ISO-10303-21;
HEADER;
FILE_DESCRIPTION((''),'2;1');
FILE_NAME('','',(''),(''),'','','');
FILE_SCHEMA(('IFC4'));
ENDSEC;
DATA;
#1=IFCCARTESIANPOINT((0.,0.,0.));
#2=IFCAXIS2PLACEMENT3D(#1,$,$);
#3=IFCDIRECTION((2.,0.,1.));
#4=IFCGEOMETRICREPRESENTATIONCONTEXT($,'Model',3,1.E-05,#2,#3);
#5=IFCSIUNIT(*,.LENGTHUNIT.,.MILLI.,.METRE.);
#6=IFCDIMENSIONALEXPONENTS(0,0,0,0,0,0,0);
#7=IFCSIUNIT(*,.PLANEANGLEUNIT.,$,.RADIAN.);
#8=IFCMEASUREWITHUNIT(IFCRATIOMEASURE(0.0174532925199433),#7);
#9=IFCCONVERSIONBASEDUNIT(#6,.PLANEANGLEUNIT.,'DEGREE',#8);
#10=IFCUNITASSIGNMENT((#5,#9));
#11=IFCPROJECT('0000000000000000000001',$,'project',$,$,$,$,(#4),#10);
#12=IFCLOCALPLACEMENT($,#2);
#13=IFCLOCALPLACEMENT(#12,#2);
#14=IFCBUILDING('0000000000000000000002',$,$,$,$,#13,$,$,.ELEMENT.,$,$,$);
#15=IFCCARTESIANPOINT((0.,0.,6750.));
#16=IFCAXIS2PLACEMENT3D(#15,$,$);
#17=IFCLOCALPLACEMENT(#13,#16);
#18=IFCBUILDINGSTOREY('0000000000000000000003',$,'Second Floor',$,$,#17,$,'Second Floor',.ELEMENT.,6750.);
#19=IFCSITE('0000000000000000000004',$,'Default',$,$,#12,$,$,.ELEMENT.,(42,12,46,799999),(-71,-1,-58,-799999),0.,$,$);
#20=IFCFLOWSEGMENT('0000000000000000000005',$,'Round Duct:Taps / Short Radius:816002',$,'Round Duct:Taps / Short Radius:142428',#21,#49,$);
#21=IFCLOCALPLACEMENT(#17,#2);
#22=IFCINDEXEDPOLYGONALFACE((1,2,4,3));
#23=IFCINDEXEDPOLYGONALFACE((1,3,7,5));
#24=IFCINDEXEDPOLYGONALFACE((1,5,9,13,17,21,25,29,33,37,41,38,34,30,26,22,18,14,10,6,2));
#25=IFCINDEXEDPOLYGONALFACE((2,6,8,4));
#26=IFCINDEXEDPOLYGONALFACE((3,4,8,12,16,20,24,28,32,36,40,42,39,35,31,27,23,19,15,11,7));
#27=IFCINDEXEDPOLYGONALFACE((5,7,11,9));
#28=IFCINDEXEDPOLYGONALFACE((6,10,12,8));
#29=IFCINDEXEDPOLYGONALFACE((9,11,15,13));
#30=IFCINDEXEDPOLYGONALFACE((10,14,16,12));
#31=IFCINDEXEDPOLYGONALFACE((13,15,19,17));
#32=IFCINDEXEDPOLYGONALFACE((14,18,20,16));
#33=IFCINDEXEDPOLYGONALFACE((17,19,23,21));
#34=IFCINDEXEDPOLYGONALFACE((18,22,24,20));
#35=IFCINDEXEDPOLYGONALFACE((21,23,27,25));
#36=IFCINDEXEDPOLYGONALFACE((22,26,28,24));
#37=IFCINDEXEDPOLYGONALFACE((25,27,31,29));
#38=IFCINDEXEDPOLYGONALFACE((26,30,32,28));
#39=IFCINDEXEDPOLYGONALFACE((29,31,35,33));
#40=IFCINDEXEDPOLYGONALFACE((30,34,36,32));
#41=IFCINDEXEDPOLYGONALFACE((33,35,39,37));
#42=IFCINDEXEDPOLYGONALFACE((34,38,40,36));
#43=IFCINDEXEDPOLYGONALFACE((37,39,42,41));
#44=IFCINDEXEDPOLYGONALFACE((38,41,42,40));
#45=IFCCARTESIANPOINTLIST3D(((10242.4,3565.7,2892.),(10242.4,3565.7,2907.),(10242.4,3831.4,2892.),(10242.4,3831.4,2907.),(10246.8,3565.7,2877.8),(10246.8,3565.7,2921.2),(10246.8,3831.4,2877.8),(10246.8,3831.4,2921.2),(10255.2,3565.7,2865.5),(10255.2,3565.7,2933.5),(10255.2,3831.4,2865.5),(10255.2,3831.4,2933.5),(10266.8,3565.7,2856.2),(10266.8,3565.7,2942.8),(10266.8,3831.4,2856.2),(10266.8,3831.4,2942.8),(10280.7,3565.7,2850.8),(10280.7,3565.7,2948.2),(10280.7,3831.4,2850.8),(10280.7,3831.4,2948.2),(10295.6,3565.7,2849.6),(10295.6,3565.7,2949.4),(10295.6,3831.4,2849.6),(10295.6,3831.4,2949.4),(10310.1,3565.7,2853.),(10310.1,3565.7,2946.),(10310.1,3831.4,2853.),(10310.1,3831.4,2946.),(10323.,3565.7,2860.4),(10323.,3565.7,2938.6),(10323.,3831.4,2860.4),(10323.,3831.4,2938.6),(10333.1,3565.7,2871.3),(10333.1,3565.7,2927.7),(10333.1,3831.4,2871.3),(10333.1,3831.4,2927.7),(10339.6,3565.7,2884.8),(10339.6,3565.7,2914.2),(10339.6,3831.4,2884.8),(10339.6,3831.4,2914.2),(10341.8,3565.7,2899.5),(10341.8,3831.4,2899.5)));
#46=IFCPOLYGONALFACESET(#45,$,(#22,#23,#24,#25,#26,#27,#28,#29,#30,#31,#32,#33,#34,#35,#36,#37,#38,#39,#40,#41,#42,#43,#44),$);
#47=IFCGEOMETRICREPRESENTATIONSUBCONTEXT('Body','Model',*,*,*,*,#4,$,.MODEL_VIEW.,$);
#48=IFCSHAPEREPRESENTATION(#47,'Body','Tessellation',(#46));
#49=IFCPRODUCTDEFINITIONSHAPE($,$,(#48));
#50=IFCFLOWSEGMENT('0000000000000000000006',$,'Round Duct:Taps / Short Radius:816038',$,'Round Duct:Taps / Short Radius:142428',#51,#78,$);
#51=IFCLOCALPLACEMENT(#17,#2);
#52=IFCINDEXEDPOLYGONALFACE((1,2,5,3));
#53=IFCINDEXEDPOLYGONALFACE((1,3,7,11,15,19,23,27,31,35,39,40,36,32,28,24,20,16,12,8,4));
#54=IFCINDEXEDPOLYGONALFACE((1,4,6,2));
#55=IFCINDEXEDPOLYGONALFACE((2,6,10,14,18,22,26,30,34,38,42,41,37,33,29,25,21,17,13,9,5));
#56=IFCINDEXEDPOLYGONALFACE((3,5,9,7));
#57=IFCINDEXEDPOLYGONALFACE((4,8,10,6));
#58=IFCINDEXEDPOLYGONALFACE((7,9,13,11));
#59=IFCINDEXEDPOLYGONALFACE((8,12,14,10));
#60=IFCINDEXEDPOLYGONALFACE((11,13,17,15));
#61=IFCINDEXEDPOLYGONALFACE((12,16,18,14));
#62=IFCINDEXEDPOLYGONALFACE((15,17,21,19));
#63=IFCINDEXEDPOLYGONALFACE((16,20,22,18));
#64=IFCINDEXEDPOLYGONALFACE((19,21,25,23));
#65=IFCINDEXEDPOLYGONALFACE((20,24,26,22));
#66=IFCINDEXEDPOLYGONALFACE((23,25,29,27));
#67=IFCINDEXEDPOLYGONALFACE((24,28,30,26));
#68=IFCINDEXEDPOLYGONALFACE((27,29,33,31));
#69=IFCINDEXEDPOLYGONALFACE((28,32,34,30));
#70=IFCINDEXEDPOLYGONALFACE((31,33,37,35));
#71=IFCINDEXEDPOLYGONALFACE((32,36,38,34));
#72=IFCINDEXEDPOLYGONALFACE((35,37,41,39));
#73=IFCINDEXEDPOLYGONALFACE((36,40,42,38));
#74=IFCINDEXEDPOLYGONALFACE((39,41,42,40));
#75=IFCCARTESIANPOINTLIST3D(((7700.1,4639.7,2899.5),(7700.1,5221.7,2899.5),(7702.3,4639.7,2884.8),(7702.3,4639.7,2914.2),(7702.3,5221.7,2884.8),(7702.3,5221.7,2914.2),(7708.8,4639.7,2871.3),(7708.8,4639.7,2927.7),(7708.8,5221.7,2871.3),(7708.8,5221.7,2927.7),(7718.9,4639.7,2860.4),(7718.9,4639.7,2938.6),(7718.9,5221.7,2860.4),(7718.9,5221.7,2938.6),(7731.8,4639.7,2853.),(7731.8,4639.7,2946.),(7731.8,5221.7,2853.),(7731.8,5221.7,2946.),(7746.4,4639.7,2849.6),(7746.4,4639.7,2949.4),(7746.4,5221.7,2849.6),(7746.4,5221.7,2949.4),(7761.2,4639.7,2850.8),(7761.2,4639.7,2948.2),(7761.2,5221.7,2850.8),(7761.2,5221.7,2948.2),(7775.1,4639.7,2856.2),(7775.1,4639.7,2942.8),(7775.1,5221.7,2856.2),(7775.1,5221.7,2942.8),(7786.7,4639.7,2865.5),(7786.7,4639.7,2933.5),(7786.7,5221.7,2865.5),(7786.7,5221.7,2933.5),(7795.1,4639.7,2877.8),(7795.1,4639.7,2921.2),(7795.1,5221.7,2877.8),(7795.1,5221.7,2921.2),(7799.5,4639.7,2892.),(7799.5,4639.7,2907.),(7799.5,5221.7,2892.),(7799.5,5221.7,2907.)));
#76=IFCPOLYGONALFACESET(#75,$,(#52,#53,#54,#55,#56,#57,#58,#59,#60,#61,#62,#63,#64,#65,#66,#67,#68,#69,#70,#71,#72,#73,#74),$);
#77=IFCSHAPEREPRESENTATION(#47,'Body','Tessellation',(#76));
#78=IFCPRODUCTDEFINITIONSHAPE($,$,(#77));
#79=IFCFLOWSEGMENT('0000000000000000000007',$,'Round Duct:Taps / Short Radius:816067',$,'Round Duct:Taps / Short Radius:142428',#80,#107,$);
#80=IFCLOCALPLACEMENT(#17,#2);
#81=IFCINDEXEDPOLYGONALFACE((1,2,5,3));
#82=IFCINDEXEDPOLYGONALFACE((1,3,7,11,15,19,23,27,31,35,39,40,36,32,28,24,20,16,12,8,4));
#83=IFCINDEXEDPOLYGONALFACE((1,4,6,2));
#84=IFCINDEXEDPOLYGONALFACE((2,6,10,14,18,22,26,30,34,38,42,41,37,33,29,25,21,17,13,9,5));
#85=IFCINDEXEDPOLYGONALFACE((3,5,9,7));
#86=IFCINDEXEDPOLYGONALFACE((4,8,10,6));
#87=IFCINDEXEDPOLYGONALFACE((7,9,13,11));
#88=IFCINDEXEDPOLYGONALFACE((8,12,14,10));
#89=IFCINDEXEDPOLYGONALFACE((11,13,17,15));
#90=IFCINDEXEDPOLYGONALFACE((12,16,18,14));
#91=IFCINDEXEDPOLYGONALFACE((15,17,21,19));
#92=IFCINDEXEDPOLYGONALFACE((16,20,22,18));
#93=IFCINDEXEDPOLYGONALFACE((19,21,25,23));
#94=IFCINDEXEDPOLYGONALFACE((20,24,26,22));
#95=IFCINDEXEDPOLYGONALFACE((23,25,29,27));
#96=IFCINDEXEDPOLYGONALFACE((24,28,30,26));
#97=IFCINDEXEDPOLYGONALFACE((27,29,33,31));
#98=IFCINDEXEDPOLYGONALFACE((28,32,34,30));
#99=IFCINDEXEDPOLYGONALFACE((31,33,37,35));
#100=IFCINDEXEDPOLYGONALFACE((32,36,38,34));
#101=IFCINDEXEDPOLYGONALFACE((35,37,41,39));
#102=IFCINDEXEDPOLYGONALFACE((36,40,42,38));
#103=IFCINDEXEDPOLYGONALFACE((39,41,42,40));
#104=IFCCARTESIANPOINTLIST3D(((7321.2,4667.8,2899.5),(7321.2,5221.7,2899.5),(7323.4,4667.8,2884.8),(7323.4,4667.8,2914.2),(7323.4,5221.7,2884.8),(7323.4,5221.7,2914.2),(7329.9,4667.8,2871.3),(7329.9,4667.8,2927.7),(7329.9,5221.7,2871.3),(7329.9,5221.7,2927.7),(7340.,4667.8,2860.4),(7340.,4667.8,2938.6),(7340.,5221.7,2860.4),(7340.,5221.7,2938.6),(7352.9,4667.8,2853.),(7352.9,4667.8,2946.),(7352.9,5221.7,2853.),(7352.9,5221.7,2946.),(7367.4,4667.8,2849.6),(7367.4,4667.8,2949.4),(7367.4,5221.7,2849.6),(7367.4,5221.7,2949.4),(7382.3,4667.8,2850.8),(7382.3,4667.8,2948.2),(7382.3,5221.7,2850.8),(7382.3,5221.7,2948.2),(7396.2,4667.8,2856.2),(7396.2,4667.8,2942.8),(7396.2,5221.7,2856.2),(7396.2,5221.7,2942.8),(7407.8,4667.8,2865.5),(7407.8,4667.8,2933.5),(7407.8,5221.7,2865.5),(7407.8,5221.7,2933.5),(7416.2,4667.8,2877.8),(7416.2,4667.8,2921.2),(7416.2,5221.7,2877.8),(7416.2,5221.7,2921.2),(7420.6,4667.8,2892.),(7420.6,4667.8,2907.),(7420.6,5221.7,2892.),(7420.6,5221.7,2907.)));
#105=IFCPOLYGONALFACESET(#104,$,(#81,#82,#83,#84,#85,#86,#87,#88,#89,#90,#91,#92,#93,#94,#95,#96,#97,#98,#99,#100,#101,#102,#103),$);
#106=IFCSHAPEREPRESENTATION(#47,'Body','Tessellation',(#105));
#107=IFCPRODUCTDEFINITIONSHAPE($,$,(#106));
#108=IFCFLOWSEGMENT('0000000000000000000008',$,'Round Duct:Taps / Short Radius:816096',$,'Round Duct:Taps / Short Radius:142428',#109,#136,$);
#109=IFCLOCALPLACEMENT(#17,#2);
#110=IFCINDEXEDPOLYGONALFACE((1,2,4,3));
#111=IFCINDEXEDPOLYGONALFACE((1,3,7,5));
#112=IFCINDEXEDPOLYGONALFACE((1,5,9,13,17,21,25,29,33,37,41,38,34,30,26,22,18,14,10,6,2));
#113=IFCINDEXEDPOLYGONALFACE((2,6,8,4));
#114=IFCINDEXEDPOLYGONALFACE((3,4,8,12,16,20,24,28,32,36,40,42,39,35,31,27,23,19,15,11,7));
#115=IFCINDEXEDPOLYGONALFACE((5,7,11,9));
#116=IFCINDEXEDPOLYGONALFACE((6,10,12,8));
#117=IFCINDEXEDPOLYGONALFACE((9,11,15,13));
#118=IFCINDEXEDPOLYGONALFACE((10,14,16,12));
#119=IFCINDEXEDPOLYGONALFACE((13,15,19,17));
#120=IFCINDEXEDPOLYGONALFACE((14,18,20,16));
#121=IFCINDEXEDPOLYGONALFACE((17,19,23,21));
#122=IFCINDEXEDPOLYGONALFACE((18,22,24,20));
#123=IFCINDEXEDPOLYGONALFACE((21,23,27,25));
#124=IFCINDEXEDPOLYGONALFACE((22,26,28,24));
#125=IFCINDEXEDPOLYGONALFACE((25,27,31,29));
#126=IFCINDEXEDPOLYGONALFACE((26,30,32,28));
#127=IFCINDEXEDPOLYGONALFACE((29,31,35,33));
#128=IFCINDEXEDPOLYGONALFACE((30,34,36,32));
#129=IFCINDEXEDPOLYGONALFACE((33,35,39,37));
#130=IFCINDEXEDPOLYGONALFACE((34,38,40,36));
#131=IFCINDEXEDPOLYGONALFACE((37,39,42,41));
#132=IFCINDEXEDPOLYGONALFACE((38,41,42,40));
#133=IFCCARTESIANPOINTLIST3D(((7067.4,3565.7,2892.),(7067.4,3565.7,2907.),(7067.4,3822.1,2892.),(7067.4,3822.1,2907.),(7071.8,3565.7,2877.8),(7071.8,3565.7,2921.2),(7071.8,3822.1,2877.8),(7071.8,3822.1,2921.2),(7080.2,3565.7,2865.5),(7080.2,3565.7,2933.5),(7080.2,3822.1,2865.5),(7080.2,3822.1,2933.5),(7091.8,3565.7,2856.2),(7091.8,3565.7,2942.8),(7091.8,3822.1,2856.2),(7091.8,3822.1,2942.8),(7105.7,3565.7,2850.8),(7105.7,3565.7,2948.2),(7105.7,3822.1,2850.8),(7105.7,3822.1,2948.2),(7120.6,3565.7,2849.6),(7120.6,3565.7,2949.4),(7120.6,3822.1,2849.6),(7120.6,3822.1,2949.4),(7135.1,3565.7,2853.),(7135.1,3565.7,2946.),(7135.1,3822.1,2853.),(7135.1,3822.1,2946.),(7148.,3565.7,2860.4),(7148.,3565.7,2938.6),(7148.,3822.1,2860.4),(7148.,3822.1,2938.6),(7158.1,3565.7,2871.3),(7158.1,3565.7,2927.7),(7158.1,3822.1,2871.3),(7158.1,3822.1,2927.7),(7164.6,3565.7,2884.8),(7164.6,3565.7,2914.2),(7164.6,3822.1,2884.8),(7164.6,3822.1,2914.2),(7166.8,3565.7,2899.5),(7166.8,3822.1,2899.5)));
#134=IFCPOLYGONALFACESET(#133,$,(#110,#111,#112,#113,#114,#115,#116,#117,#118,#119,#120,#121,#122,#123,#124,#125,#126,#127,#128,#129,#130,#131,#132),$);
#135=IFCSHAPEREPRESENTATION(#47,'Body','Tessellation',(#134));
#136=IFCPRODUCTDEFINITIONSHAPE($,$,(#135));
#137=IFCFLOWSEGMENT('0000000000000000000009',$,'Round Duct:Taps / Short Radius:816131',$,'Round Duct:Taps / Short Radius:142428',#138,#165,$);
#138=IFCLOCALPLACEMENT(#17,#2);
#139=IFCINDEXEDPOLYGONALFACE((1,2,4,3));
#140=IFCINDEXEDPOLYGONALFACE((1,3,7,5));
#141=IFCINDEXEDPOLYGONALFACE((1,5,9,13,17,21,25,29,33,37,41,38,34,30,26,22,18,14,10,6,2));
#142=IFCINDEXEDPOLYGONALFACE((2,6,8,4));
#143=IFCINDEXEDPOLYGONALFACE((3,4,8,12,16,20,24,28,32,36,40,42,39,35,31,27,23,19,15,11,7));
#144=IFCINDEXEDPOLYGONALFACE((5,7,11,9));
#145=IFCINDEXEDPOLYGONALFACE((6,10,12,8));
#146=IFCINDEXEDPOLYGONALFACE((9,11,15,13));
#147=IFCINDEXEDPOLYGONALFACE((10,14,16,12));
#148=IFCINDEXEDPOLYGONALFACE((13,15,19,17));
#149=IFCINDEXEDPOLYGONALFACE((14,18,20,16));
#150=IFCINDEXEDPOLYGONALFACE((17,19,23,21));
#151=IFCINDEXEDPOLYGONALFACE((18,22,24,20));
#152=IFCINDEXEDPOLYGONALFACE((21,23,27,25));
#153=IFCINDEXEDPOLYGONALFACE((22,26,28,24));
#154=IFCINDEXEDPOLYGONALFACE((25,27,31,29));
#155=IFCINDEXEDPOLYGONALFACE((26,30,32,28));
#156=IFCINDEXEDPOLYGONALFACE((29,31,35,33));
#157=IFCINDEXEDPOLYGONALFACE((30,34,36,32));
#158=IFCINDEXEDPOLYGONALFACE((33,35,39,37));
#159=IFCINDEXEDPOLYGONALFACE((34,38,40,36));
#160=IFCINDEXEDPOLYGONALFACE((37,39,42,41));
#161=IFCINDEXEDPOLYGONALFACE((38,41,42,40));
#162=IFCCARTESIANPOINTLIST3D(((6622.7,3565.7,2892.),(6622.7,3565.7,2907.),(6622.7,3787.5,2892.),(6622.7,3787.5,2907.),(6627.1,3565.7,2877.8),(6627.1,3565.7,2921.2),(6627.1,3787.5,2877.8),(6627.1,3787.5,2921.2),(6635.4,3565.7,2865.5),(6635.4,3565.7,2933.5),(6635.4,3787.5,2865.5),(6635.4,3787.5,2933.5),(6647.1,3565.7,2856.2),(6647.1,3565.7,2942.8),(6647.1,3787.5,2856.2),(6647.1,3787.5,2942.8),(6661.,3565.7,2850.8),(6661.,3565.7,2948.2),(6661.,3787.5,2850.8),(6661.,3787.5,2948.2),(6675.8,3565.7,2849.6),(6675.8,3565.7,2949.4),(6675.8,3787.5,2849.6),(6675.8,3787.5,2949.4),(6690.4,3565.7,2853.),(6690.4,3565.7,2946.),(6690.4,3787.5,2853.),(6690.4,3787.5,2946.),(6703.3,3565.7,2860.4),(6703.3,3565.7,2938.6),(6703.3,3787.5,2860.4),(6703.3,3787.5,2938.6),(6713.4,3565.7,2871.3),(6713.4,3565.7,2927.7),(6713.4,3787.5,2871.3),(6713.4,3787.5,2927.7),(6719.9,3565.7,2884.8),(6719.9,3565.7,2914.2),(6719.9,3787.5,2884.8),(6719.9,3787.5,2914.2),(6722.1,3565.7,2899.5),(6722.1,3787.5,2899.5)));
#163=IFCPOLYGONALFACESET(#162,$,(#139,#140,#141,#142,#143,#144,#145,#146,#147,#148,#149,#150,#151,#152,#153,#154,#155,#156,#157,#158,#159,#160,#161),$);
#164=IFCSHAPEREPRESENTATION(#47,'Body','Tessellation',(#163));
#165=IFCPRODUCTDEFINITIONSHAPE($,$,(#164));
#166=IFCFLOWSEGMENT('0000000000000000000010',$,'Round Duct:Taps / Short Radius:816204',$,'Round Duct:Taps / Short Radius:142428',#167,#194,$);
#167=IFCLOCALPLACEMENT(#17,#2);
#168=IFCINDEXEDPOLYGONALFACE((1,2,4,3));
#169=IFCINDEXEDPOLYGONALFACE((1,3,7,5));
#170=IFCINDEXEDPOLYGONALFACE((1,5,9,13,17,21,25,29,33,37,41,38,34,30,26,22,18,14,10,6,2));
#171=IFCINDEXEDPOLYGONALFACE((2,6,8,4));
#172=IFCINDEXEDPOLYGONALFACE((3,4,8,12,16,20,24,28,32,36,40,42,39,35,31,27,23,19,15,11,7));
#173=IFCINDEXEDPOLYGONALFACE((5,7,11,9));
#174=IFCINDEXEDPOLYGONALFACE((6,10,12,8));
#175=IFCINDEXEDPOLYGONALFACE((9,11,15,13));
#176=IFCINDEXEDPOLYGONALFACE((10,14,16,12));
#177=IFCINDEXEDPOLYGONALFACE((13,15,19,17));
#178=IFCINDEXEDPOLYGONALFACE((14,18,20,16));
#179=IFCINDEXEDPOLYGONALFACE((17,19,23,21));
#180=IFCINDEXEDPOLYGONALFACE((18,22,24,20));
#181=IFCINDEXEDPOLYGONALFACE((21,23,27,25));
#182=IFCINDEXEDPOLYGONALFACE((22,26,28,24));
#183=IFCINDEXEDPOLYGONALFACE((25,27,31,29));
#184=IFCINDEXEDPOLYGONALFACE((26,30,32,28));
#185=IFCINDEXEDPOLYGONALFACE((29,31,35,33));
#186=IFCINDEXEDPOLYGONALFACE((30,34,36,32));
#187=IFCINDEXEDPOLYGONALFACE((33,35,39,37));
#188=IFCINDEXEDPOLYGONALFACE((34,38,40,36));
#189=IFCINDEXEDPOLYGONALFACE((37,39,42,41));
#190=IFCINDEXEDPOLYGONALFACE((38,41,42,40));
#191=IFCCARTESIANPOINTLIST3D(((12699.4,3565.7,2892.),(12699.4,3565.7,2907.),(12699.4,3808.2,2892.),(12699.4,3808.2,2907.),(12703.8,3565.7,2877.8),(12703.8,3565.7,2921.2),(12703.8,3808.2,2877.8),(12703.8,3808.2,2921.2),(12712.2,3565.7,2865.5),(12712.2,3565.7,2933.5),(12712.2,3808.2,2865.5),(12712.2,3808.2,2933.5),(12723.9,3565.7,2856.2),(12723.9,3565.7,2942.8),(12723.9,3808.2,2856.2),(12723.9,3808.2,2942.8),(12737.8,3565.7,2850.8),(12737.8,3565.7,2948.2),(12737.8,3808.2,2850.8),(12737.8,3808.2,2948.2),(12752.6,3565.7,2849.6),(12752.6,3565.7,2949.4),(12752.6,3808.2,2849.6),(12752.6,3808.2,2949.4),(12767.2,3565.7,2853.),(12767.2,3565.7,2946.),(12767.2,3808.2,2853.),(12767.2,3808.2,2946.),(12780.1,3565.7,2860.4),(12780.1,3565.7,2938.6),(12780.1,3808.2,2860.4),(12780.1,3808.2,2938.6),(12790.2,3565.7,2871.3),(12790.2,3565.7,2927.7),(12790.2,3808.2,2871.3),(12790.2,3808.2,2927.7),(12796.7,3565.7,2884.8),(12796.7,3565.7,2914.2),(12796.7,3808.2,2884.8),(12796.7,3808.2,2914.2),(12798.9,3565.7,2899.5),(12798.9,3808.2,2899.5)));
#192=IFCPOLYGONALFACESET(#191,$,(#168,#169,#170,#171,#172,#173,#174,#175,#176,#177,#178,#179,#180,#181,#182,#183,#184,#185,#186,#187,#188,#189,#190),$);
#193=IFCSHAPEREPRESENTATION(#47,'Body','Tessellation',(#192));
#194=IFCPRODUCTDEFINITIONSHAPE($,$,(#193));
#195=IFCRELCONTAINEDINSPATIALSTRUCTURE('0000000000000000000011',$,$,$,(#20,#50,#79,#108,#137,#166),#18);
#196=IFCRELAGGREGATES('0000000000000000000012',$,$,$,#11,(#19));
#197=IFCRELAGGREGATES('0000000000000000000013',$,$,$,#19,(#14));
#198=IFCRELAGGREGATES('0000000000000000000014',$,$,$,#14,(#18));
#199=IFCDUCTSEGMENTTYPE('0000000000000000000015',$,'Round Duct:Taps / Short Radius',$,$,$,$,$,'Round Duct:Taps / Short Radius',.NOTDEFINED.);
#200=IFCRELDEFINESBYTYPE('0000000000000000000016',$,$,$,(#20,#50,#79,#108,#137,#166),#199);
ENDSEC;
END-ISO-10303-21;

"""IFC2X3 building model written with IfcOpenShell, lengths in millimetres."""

from ifc_helpers import new_model, entity, si_unit, converted_unit, direction, frame, frame_2d, origin, origin_2d_with_axis, place, context, subcontext, project, spatial, circle, extrude, type_object, element, save


model = new_model("IFC2X3")

# Units and contexts
model_context = context("Model", 3, precision=1e-05, world=origin(), true_north=direction((2.0, 0.0, 1.0)))
body_context = subcontext(model_context, "Body", "Model", "MODEL_VIEW")
ifc_project = project(units=[si_unit("LENGTHUNIT", "METRE", prefix="MILLI"), converted_unit("PLANEANGLEUNIT", "DEGREE", entity("IfcRatioMeasure", 0.0174532925199433), si_unit("PLANEANGLEUNIT", "RADIAN"), dimensions=[0, 0, 0, 0, 0, 0, 0])], contexts=[model_context])

# Site, building, storey
site_placement = place(None, origin())
site = spatial("IfcSite", under=ifc_project, at=site_placement, Name="Default", CompositionType="ELEMENT", RefLatitude=(42, 12, 46, 799999), RefLongitude=(-71, -1, -58, -799999), RefElevation=0.0)
building_placement = place(site_placement, origin())
building = spatial("IfcBuilding", under=site, at=building_placement, CompositionType="ELEMENT")
storey_placement = place(building_placement, frame((0.0, 0.0, 6750.0)))
storey = spatial("IfcBuildingStorey", under=building, at=storey_placement, Name="Second Floor", LongName="Second Floor", CompositionType="ELEMENT", Elevation=6750.0)

# Flow segments
duct_segment_type = type_object("IfcDuctSegmentType", Name="Round Duct:Taps / Short Radius", ElementType="Round Duct:Taps / Short Radius", PredefinedType="NOTDEFINED")
flow_segment_1_placement = place(storey_placement, origin())
element("IfcFlowSegment", 1, at=flow_segment_1_placement, inside=storey, type_object=duct_segment_type, Name="Round Duct:Taps / Short Radius:816002", ObjectType="Round Duct:Taps / Short Radius:142428", context=body_context, shape_type="SweptSolid", body=[
    extrude(circle(Radius=50.0, at=origin_2d_with_axis()), frame((10291.8, 3565.7, 2899.5), z_axis=(0.0, 1.0, 0.0), x_axis=(1.0, 0.0, 0.0)), (0.0, 0.0, 1.0), 265.7),
])
flow_segment_2_placement = place(storey_placement, origin())
element("IfcFlowSegment", 2, at=flow_segment_2_placement, inside=storey, type_object=duct_segment_type, Name="Round Duct:Taps / Short Radius:816038", ObjectType="Round Duct:Taps / Short Radius:142428", context=body_context, shape_type="SweptSolid", body=[
    extrude(circle(Radius=50.0, at=frame_2d((0.0, 0.0), x_axis=(1.0, 0.0))), frame((7750.1, 4639.7, 2899.5), z_axis=(0.0, 1.0, 0.0), x_axis=(-1.0, 0.0, 0.0)), (0.0, 0.0, 1.0), 581.9),
])
flow_segment_3_placement = place(storey_placement, origin())
element("IfcFlowSegment", 3, at=flow_segment_3_placement, inside=storey, type_object=duct_segment_type, Name="Round Duct:Taps / Short Radius:816067", ObjectType="Round Duct:Taps / Short Radius:142428", context=body_context, shape_type="SweptSolid", body=[
    extrude(circle(Radius=50.0, at=frame_2d((0.0, 0.0), x_axis=(1.0, 0.0))), frame((7371.2, 4667.8, 2899.5), z_axis=(0.0, 1.0, 0.0), x_axis=(-1.0, 0.0, 0.0)), (0.0, 0.0, 1.0), 553.9),
])
flow_segment_4_placement = place(storey_placement, origin())
element("IfcFlowSegment", 4, at=flow_segment_4_placement, inside=storey, type_object=duct_segment_type, Name="Round Duct:Taps / Short Radius:816096", ObjectType="Round Duct:Taps / Short Radius:142428", context=body_context, shape_type="SweptSolid", body=[
    extrude(circle(Radius=50.0, at=origin_2d_with_axis()), frame((7116.8, 3565.7, 2899.5), z_axis=(0.0, 1.0, 0.0), x_axis=(1.0, 0.0, 0.0)), (0.0, 0.0, 1.0), 256.5),
])
flow_segment_5_placement = place(storey_placement, origin())
element("IfcFlowSegment", 5, at=flow_segment_5_placement, inside=storey, type_object=duct_segment_type, Name="Round Duct:Taps / Short Radius:816131", ObjectType="Round Duct:Taps / Short Radius:142428", context=body_context, shape_type="SweptSolid", body=[
    extrude(circle(Radius=50.0, at=frame_2d((0.0, 0.0), x_axis=(1.0, 0.0))), frame((6672.1, 3565.7, 2899.5), z_axis=(0.0, 1.0, 0.0), x_axis=(1.0, 0.0, 0.0)), (0.0, 0.0, 1.0), 221.8),
])
flow_segment_6_placement = place(storey_placement, origin())
element("IfcFlowSegment", 6, at=flow_segment_6_placement, inside=storey, type_object=duct_segment_type, Name="Round Duct:Taps / Short Radius:816204", ObjectType="Round Duct:Taps / Short Radius:142428", context=body_context, shape_type="SweptSolid", body=[
    extrude(circle(Radius=50.0, at=origin_2d_with_axis()), frame((12748.9, 3565.7, 2899.5), z_axis=(0.0, 1.0, 0.0), x_axis=(1.0, 0.0, 0.0)), (0.0, 0.0, 1.0), 242.5),
])

save(model, "model.ifc")
